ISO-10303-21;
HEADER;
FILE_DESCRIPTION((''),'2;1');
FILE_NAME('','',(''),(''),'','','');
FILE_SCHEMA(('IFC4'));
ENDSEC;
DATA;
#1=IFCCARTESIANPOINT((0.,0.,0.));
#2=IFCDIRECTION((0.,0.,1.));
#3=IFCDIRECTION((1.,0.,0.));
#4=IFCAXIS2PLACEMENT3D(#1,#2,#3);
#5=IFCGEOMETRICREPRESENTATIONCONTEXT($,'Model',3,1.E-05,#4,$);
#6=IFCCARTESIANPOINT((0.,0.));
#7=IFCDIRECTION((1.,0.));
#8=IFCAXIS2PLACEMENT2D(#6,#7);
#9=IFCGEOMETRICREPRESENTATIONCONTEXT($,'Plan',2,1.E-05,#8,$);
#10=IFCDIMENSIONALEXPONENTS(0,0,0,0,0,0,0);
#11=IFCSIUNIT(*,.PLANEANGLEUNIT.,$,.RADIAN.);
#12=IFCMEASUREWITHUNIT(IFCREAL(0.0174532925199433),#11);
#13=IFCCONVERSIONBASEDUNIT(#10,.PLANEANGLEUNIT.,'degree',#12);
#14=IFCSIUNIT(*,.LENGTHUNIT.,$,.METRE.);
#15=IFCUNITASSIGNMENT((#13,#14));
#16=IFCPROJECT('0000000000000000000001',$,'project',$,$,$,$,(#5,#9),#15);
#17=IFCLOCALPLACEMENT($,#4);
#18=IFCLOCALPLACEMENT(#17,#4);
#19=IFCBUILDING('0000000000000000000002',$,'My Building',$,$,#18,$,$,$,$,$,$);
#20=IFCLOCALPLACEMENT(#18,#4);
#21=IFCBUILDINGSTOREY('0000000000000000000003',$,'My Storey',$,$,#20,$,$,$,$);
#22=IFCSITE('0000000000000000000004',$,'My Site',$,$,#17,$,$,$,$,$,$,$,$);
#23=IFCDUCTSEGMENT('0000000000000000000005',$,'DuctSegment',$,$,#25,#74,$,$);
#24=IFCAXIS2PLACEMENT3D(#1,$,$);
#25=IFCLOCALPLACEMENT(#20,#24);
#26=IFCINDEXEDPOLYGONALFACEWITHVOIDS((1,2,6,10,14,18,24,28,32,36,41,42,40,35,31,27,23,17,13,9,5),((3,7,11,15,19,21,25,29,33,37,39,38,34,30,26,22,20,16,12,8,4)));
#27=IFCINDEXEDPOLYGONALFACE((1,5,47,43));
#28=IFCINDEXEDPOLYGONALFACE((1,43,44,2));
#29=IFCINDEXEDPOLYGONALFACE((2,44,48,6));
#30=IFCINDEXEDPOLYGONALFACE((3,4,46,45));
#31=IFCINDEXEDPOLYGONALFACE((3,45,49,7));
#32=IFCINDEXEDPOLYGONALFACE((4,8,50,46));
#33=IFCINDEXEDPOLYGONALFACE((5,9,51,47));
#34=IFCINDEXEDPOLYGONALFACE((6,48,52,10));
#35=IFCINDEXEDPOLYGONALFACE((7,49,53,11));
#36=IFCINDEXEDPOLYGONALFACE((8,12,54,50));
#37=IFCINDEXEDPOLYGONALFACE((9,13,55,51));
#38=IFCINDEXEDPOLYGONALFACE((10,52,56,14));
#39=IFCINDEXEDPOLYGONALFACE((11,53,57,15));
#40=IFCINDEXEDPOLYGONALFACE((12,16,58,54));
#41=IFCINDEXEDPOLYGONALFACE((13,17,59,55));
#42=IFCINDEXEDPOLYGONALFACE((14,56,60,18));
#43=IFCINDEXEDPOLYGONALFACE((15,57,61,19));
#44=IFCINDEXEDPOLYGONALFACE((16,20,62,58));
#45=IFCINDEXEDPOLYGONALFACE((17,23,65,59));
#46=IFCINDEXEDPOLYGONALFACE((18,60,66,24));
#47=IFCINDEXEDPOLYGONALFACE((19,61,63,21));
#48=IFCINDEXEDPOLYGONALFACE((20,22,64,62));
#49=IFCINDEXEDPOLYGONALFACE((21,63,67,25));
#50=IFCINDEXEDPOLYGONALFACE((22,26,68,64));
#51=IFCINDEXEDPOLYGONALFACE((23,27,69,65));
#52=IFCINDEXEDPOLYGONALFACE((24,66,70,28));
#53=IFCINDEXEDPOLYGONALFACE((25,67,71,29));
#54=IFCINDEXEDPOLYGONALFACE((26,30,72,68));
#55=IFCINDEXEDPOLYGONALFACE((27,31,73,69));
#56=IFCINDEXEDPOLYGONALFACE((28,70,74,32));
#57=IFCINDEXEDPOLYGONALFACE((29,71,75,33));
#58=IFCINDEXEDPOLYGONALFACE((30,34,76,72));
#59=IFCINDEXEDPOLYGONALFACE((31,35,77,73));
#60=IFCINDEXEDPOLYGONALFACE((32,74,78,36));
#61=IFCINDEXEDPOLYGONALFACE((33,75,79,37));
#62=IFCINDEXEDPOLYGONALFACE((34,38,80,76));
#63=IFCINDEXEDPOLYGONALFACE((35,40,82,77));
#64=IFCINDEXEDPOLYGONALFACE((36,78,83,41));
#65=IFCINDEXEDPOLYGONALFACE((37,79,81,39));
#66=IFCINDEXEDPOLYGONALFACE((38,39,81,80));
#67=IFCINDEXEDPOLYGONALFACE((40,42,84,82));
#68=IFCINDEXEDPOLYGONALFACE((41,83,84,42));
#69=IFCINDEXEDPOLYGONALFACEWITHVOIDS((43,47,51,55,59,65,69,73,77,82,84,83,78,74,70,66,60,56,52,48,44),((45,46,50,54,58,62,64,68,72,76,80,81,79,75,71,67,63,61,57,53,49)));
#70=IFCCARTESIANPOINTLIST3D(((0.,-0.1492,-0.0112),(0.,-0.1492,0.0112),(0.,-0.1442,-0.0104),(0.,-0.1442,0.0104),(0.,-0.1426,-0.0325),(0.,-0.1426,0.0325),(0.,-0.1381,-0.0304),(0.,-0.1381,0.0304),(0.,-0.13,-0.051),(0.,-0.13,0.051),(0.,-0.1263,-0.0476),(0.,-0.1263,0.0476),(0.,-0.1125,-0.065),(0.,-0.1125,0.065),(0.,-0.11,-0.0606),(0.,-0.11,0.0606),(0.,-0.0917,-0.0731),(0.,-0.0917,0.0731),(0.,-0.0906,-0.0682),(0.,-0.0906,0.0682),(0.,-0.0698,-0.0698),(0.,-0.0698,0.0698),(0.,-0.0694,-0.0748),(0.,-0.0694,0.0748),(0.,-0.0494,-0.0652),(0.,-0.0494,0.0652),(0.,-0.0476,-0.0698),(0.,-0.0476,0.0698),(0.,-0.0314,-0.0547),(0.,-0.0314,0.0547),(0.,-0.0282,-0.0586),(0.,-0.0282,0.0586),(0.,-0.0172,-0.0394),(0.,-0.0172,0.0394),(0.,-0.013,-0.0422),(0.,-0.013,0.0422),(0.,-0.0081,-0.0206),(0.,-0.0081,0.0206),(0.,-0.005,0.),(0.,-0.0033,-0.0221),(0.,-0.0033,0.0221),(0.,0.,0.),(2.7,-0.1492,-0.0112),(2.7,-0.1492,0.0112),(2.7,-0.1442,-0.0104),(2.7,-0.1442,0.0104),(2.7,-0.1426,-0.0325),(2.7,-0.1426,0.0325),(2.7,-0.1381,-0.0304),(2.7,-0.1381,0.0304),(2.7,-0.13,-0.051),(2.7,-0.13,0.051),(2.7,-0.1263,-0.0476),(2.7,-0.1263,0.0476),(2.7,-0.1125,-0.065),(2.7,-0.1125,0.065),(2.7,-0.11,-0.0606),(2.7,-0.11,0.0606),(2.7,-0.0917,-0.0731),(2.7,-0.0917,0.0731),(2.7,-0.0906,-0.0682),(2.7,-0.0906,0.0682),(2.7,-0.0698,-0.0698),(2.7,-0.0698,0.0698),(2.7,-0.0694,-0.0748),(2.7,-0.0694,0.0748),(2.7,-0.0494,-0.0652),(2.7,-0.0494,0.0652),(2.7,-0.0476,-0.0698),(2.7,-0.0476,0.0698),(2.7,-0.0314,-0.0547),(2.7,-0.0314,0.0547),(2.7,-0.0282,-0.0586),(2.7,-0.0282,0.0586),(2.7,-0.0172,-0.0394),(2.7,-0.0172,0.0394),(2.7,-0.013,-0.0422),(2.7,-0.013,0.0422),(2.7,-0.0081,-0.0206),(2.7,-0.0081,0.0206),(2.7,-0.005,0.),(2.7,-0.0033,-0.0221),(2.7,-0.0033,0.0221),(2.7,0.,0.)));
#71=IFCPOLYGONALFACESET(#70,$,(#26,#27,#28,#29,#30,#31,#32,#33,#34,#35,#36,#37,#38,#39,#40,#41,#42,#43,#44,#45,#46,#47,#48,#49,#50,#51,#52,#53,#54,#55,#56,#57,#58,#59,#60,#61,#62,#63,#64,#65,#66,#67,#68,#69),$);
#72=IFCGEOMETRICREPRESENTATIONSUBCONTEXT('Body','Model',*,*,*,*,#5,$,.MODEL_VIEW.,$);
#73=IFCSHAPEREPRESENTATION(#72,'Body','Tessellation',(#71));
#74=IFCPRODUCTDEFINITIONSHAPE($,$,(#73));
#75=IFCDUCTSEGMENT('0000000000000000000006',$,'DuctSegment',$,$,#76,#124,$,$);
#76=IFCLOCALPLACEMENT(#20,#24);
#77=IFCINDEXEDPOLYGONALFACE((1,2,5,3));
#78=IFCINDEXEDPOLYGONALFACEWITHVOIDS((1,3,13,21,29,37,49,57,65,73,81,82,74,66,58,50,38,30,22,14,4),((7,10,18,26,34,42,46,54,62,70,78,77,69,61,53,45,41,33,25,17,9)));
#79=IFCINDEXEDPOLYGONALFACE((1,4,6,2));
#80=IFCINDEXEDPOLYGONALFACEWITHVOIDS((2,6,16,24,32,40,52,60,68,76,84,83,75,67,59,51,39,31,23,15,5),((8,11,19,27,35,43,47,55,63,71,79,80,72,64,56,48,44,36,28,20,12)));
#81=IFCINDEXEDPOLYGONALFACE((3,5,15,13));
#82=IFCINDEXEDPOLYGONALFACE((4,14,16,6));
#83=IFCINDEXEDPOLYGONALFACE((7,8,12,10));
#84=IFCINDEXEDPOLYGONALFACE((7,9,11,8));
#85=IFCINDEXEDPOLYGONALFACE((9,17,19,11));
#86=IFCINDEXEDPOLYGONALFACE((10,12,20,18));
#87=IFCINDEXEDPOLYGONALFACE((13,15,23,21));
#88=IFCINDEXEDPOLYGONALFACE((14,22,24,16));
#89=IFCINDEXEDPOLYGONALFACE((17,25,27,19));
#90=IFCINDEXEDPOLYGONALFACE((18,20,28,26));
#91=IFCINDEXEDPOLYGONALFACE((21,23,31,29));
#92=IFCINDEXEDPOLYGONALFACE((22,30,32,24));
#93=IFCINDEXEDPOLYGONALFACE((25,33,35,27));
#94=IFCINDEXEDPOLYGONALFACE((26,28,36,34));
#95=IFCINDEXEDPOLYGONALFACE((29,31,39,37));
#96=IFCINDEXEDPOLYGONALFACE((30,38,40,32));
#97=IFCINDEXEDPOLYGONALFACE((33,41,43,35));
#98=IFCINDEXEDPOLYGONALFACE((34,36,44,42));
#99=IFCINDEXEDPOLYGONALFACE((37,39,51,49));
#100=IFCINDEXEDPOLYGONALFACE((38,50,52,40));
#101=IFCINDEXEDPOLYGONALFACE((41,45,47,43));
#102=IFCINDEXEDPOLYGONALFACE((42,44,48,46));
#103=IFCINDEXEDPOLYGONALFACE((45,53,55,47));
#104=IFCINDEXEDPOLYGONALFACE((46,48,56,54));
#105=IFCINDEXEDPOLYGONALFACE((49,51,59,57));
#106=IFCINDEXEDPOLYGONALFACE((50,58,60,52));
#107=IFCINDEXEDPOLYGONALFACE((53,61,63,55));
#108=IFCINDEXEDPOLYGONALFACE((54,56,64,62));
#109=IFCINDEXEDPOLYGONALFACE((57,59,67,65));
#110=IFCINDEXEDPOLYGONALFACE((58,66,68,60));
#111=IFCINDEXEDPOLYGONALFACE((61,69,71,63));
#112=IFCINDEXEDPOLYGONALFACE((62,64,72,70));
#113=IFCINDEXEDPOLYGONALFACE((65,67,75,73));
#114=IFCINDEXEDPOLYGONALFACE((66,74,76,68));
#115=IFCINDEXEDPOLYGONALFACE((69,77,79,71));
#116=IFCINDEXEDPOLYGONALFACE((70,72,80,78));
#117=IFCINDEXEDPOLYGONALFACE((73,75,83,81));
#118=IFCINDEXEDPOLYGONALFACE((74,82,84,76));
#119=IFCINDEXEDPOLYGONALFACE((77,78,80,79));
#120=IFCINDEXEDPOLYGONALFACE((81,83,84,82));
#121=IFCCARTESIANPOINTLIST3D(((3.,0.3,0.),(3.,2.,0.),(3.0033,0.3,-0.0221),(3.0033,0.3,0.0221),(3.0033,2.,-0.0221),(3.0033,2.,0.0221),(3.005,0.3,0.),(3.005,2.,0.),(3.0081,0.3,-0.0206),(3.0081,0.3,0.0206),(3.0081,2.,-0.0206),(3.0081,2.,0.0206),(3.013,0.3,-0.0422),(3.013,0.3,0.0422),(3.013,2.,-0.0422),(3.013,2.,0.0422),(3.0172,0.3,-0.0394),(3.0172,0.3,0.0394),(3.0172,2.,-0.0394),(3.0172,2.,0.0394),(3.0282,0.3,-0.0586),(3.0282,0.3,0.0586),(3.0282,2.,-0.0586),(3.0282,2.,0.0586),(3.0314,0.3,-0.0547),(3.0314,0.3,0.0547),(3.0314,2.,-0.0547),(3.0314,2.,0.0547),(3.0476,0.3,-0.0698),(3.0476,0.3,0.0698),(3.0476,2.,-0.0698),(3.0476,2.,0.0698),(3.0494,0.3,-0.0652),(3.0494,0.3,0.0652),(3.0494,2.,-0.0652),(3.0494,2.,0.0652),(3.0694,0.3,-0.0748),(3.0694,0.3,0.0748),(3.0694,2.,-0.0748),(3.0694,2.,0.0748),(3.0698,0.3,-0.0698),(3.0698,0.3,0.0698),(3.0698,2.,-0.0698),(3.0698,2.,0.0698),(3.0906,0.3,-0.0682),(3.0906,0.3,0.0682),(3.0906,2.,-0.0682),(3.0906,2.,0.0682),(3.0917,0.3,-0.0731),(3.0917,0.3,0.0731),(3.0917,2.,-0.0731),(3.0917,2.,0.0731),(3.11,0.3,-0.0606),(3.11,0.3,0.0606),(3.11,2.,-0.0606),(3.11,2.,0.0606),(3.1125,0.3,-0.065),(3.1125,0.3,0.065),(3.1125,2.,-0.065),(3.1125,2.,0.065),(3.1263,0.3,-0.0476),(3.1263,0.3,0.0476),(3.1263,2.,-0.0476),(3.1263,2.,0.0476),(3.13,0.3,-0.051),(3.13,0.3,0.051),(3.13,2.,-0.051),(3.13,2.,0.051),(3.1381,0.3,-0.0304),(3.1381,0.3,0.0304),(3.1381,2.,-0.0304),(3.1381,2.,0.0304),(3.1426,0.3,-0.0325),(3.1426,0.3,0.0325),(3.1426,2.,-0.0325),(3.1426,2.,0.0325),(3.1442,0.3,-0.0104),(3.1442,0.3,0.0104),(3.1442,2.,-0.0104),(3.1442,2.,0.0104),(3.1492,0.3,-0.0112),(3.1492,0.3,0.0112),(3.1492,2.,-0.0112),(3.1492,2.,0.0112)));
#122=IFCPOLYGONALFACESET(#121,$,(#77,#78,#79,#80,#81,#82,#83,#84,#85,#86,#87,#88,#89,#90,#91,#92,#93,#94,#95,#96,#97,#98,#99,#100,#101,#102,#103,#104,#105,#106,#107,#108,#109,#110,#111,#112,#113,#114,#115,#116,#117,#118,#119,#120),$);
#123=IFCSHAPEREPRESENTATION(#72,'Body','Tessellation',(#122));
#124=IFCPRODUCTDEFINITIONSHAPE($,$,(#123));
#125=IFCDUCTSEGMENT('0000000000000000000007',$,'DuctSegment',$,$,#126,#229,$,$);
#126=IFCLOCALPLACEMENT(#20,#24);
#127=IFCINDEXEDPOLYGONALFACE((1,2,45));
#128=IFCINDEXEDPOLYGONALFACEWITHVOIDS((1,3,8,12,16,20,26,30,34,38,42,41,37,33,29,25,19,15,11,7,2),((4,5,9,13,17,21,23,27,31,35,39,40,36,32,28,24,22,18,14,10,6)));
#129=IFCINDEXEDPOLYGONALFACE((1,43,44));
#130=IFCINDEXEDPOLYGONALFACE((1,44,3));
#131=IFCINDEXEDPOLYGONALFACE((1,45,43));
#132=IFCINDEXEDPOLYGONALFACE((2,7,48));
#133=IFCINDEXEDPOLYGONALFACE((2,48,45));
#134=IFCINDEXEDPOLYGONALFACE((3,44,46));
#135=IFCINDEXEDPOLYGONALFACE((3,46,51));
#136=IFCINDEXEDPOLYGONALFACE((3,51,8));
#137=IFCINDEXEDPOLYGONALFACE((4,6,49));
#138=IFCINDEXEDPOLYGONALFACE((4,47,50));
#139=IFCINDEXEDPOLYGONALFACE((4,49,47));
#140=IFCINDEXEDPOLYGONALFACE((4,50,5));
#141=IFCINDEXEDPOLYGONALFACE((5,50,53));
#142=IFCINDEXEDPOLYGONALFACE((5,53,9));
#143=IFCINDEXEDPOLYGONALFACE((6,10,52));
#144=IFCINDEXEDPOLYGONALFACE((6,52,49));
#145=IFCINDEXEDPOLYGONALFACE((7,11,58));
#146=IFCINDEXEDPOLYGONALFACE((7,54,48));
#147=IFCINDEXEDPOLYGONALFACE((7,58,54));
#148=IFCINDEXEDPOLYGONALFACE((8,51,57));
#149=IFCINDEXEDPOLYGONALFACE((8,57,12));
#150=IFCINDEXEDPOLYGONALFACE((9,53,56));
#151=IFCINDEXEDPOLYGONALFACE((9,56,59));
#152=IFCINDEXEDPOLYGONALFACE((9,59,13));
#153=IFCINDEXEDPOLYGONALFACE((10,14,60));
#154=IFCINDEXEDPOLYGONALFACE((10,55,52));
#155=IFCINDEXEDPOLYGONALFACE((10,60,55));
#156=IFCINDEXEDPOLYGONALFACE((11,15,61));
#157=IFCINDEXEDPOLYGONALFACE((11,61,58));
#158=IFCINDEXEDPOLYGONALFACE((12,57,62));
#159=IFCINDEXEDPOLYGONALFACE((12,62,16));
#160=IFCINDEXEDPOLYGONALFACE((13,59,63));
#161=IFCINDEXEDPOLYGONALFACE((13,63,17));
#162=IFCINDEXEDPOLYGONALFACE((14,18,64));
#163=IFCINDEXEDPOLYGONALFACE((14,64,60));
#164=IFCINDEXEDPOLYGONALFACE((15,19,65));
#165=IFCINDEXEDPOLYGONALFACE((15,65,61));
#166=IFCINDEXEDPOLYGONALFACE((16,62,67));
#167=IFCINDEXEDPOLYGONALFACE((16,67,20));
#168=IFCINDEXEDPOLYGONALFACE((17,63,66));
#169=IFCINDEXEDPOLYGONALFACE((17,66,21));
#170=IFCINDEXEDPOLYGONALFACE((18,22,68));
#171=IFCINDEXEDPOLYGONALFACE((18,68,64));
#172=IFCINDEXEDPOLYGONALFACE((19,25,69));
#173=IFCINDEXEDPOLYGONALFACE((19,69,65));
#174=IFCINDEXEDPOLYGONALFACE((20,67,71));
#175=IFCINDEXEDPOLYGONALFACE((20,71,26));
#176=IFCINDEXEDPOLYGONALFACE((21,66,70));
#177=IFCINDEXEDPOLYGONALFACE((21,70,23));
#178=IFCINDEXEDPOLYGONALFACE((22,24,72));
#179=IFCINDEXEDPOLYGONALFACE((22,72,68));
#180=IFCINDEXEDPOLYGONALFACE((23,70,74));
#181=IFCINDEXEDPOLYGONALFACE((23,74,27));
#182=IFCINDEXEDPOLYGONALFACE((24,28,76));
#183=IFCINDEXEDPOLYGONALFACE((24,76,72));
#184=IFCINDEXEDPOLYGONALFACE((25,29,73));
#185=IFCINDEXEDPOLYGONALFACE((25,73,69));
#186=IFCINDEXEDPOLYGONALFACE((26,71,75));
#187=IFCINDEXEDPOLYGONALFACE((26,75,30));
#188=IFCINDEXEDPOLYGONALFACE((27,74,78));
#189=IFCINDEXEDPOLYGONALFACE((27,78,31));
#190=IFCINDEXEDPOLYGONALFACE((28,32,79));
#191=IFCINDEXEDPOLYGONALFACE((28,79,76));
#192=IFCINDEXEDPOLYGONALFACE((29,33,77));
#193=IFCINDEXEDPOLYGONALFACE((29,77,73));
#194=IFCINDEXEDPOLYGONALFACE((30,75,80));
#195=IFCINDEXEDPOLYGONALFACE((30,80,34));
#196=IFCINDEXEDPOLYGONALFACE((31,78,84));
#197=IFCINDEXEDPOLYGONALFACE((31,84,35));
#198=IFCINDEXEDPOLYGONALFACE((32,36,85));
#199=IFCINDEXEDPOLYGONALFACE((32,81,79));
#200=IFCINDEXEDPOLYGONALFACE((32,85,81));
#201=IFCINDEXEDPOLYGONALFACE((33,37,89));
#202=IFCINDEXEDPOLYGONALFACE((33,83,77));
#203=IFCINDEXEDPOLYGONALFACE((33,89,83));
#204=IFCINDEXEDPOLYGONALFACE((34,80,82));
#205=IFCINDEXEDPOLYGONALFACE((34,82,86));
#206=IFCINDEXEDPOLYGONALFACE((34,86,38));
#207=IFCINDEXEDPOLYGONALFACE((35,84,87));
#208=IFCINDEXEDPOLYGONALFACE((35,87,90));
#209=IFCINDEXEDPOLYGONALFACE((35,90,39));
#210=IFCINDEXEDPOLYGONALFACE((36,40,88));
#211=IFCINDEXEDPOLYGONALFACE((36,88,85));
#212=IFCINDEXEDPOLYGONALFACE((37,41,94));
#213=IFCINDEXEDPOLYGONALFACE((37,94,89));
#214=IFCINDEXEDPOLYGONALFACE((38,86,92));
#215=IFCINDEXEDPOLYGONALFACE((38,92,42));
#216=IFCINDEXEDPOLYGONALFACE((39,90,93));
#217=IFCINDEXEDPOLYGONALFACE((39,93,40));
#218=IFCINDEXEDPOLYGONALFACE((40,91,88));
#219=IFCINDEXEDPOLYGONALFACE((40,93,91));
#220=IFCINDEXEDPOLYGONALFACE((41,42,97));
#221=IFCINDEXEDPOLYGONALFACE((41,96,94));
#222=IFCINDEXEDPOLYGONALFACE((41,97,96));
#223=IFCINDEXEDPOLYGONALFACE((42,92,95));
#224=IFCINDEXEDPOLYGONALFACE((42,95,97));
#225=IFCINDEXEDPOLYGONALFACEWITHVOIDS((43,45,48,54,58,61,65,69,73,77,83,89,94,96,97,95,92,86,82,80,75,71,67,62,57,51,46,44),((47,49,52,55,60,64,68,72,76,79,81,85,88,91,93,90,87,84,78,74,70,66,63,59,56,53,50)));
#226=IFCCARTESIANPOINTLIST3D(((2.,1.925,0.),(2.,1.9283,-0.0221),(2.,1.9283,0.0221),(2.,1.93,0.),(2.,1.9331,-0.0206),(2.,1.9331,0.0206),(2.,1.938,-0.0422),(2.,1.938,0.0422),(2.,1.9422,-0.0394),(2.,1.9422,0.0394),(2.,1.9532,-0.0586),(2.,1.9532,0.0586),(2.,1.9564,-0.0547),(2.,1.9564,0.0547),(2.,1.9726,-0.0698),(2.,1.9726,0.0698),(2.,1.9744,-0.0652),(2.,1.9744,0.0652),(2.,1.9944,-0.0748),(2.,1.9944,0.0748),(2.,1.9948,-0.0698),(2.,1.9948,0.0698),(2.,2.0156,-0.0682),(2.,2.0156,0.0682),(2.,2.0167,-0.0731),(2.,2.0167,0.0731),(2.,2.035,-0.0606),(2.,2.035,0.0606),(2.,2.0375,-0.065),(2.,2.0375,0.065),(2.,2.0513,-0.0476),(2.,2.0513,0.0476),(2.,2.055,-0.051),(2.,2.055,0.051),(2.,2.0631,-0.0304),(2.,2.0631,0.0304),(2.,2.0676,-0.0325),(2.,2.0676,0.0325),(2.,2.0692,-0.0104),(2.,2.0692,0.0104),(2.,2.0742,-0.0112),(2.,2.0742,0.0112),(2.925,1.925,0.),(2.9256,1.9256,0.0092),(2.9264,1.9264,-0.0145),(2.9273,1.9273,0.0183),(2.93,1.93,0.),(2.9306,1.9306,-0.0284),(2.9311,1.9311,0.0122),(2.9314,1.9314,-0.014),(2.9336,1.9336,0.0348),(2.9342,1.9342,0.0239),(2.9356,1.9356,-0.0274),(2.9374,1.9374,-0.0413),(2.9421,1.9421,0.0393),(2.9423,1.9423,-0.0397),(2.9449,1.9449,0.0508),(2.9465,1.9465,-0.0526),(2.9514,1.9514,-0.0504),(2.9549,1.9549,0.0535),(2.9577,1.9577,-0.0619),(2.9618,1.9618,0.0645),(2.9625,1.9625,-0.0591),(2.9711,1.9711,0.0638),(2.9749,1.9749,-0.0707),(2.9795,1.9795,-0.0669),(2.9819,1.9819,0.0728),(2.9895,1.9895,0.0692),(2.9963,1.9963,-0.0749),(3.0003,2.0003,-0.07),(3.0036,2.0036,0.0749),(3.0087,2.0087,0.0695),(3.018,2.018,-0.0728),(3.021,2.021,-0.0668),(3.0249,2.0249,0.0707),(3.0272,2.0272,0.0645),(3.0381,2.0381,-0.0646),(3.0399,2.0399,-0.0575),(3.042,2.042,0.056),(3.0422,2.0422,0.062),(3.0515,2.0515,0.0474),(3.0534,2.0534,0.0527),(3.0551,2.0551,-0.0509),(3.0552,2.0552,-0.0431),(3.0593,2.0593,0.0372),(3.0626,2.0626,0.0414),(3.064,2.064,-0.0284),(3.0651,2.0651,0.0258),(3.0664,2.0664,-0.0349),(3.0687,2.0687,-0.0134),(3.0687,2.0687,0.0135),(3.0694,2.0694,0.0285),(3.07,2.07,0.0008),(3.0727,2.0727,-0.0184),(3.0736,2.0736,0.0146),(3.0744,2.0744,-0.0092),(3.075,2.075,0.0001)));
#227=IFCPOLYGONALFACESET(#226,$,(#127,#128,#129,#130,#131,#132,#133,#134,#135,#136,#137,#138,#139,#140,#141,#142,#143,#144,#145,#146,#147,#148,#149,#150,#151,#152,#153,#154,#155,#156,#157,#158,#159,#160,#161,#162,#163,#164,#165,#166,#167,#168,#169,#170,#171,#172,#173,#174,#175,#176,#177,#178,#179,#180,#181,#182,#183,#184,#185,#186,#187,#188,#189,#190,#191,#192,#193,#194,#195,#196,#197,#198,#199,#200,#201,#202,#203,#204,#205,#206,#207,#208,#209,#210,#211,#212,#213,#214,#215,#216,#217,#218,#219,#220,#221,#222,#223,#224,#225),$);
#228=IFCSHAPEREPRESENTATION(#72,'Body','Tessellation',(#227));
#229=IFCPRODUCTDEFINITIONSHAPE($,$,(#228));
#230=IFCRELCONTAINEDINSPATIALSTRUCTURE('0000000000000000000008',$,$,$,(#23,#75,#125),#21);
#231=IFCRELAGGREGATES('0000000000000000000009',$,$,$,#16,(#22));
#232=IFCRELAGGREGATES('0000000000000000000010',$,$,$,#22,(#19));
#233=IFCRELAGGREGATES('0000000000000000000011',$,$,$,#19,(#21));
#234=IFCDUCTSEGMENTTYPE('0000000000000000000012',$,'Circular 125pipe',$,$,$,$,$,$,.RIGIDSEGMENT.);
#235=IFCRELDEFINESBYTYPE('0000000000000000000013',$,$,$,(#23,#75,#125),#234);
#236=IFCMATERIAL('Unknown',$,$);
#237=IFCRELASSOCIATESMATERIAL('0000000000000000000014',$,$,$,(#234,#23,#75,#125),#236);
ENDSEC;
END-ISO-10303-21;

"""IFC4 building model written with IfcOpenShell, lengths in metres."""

from ifc_helpers import new_model, entity, si_unit, converted_unit, frame, origin_with_axes, origin_2d_with_axis, place, context, subcontext, project, spatial, hollow_circle, extrude, clip, halfspace, material, material_profile, profile_set, profile_usage, type_object, element, save


model = new_model("IFC4")

# Units and contexts
model_context = context("Model", 3, precision=1e-05, world=origin_with_axes())
plan_context = context("Plan", 2, precision=1e-05, world=origin_2d_with_axis())
body_context = subcontext(model_context, "Body", "Model", "MODEL_VIEW")
ifc_project = project(units=[converted_unit("PLANEANGLEUNIT", "degree", entity("IfcReal", 0.0174532925199433), si_unit("PLANEANGLEUNIT", "RADIAN"), dimensions=[0, 0, 0, 0, 0, 0, 0]), si_unit("LENGTHUNIT", "METRE")], contexts=[model_context, plan_context])

# Site, building, storey
site_placement = place(None, origin_with_axes())
site = spatial("IfcSite", under=ifc_project, at=site_placement, Name="My Site")
building_placement = place(site_placement, origin_with_axes())
building = spatial("IfcBuilding", under=site, at=building_placement, Name="My Building")
storey_placement = place(building_placement, origin_with_axes())
storey = spatial("IfcBuildingStorey", under=building, at=storey_placement, Name="My Storey")

# Duct segments
ifc_material = material(Name="Unknown")
ifc_material_profile = material_profile(ifc_material, hollow_circle(Radius=0.075, WallThickness=0.005))
ifc_profile_set = profile_set([ifc_material_profile])
ifc_profile_usage_1 = profile_usage(ifc_profile_set, cardinal=5)
duct_segment_type = type_object("IfcDuctSegmentType", Name="Circular 125pipe", PredefinedType="RIGIDSEGMENT", material=ifc_profile_set)
duct_segment_1_placement = place(storey_placement, frame((0.0, -0.075, 0.0), z_axis=(1.0, 0.0, 0.0), x_axis=(0.0, 1.0, 0.0)))
element("IfcDuctSegment", 1, at=duct_segment_1_placement, inside=storey, type_object=duct_segment_type, material=ifc_profile_usage_1, Name="DuctSegment", context=body_context, shape_type="SweptSolid", body=[
    extrude(hollow_circle(Radius=0.075, WallThickness=0.005), origin_with_axes(), (0.0, 0.0, 1.0), 2.7),
])
ifc_profile_usage_2 = profile_usage(ifc_profile_set, cardinal=5)
duct_segment_2_placement = place(storey_placement, frame((3.075, 0.3, 0.0), z_axis=(0.0, 1.0, 0.0), x_axis=(-1.0, 0.0, 0.0)))
element("IfcDuctSegment", 2, at=duct_segment_2_placement, inside=storey, type_object=duct_segment_type, material=ifc_profile_usage_2, Name="DuctSegment", context=body_context, shape_type="SweptSolid", body=[
    extrude(hollow_circle(Radius=0.075, WallThickness=0.005), origin_with_axes(), (0.0, 0.0, 1.0), 1.7),
])
ifc_profile_usage_3 = profile_usage(ifc_profile_set, cardinal=5)
duct_segment_3_placement = place(storey_placement, frame((3.075, 2.0, 0.0), z_axis=(-1.0, 0.0, 0.0), x_axis=(0.0, -1.0, 0.0)))
element("IfcDuctSegment", 3, at=duct_segment_3_placement, inside=storey, type_object=duct_segment_type, material=ifc_profile_usage_3, Name="DuctSegment", context=body_context, shape_type="Clipping", body=[
    clip(extrude(hollow_circle(Radius=0.075, WallThickness=0.005), origin_with_axes(), (0.0, 0.0, 1.0), 1.075), halfspace(frame((-0.075, 0.0, 0.0), z_axis=(0.707107, 0.0, -0.707106), x_axis=(0.0, -1.0, 0.0)), False)),
])

save(model, "model.ifc")
